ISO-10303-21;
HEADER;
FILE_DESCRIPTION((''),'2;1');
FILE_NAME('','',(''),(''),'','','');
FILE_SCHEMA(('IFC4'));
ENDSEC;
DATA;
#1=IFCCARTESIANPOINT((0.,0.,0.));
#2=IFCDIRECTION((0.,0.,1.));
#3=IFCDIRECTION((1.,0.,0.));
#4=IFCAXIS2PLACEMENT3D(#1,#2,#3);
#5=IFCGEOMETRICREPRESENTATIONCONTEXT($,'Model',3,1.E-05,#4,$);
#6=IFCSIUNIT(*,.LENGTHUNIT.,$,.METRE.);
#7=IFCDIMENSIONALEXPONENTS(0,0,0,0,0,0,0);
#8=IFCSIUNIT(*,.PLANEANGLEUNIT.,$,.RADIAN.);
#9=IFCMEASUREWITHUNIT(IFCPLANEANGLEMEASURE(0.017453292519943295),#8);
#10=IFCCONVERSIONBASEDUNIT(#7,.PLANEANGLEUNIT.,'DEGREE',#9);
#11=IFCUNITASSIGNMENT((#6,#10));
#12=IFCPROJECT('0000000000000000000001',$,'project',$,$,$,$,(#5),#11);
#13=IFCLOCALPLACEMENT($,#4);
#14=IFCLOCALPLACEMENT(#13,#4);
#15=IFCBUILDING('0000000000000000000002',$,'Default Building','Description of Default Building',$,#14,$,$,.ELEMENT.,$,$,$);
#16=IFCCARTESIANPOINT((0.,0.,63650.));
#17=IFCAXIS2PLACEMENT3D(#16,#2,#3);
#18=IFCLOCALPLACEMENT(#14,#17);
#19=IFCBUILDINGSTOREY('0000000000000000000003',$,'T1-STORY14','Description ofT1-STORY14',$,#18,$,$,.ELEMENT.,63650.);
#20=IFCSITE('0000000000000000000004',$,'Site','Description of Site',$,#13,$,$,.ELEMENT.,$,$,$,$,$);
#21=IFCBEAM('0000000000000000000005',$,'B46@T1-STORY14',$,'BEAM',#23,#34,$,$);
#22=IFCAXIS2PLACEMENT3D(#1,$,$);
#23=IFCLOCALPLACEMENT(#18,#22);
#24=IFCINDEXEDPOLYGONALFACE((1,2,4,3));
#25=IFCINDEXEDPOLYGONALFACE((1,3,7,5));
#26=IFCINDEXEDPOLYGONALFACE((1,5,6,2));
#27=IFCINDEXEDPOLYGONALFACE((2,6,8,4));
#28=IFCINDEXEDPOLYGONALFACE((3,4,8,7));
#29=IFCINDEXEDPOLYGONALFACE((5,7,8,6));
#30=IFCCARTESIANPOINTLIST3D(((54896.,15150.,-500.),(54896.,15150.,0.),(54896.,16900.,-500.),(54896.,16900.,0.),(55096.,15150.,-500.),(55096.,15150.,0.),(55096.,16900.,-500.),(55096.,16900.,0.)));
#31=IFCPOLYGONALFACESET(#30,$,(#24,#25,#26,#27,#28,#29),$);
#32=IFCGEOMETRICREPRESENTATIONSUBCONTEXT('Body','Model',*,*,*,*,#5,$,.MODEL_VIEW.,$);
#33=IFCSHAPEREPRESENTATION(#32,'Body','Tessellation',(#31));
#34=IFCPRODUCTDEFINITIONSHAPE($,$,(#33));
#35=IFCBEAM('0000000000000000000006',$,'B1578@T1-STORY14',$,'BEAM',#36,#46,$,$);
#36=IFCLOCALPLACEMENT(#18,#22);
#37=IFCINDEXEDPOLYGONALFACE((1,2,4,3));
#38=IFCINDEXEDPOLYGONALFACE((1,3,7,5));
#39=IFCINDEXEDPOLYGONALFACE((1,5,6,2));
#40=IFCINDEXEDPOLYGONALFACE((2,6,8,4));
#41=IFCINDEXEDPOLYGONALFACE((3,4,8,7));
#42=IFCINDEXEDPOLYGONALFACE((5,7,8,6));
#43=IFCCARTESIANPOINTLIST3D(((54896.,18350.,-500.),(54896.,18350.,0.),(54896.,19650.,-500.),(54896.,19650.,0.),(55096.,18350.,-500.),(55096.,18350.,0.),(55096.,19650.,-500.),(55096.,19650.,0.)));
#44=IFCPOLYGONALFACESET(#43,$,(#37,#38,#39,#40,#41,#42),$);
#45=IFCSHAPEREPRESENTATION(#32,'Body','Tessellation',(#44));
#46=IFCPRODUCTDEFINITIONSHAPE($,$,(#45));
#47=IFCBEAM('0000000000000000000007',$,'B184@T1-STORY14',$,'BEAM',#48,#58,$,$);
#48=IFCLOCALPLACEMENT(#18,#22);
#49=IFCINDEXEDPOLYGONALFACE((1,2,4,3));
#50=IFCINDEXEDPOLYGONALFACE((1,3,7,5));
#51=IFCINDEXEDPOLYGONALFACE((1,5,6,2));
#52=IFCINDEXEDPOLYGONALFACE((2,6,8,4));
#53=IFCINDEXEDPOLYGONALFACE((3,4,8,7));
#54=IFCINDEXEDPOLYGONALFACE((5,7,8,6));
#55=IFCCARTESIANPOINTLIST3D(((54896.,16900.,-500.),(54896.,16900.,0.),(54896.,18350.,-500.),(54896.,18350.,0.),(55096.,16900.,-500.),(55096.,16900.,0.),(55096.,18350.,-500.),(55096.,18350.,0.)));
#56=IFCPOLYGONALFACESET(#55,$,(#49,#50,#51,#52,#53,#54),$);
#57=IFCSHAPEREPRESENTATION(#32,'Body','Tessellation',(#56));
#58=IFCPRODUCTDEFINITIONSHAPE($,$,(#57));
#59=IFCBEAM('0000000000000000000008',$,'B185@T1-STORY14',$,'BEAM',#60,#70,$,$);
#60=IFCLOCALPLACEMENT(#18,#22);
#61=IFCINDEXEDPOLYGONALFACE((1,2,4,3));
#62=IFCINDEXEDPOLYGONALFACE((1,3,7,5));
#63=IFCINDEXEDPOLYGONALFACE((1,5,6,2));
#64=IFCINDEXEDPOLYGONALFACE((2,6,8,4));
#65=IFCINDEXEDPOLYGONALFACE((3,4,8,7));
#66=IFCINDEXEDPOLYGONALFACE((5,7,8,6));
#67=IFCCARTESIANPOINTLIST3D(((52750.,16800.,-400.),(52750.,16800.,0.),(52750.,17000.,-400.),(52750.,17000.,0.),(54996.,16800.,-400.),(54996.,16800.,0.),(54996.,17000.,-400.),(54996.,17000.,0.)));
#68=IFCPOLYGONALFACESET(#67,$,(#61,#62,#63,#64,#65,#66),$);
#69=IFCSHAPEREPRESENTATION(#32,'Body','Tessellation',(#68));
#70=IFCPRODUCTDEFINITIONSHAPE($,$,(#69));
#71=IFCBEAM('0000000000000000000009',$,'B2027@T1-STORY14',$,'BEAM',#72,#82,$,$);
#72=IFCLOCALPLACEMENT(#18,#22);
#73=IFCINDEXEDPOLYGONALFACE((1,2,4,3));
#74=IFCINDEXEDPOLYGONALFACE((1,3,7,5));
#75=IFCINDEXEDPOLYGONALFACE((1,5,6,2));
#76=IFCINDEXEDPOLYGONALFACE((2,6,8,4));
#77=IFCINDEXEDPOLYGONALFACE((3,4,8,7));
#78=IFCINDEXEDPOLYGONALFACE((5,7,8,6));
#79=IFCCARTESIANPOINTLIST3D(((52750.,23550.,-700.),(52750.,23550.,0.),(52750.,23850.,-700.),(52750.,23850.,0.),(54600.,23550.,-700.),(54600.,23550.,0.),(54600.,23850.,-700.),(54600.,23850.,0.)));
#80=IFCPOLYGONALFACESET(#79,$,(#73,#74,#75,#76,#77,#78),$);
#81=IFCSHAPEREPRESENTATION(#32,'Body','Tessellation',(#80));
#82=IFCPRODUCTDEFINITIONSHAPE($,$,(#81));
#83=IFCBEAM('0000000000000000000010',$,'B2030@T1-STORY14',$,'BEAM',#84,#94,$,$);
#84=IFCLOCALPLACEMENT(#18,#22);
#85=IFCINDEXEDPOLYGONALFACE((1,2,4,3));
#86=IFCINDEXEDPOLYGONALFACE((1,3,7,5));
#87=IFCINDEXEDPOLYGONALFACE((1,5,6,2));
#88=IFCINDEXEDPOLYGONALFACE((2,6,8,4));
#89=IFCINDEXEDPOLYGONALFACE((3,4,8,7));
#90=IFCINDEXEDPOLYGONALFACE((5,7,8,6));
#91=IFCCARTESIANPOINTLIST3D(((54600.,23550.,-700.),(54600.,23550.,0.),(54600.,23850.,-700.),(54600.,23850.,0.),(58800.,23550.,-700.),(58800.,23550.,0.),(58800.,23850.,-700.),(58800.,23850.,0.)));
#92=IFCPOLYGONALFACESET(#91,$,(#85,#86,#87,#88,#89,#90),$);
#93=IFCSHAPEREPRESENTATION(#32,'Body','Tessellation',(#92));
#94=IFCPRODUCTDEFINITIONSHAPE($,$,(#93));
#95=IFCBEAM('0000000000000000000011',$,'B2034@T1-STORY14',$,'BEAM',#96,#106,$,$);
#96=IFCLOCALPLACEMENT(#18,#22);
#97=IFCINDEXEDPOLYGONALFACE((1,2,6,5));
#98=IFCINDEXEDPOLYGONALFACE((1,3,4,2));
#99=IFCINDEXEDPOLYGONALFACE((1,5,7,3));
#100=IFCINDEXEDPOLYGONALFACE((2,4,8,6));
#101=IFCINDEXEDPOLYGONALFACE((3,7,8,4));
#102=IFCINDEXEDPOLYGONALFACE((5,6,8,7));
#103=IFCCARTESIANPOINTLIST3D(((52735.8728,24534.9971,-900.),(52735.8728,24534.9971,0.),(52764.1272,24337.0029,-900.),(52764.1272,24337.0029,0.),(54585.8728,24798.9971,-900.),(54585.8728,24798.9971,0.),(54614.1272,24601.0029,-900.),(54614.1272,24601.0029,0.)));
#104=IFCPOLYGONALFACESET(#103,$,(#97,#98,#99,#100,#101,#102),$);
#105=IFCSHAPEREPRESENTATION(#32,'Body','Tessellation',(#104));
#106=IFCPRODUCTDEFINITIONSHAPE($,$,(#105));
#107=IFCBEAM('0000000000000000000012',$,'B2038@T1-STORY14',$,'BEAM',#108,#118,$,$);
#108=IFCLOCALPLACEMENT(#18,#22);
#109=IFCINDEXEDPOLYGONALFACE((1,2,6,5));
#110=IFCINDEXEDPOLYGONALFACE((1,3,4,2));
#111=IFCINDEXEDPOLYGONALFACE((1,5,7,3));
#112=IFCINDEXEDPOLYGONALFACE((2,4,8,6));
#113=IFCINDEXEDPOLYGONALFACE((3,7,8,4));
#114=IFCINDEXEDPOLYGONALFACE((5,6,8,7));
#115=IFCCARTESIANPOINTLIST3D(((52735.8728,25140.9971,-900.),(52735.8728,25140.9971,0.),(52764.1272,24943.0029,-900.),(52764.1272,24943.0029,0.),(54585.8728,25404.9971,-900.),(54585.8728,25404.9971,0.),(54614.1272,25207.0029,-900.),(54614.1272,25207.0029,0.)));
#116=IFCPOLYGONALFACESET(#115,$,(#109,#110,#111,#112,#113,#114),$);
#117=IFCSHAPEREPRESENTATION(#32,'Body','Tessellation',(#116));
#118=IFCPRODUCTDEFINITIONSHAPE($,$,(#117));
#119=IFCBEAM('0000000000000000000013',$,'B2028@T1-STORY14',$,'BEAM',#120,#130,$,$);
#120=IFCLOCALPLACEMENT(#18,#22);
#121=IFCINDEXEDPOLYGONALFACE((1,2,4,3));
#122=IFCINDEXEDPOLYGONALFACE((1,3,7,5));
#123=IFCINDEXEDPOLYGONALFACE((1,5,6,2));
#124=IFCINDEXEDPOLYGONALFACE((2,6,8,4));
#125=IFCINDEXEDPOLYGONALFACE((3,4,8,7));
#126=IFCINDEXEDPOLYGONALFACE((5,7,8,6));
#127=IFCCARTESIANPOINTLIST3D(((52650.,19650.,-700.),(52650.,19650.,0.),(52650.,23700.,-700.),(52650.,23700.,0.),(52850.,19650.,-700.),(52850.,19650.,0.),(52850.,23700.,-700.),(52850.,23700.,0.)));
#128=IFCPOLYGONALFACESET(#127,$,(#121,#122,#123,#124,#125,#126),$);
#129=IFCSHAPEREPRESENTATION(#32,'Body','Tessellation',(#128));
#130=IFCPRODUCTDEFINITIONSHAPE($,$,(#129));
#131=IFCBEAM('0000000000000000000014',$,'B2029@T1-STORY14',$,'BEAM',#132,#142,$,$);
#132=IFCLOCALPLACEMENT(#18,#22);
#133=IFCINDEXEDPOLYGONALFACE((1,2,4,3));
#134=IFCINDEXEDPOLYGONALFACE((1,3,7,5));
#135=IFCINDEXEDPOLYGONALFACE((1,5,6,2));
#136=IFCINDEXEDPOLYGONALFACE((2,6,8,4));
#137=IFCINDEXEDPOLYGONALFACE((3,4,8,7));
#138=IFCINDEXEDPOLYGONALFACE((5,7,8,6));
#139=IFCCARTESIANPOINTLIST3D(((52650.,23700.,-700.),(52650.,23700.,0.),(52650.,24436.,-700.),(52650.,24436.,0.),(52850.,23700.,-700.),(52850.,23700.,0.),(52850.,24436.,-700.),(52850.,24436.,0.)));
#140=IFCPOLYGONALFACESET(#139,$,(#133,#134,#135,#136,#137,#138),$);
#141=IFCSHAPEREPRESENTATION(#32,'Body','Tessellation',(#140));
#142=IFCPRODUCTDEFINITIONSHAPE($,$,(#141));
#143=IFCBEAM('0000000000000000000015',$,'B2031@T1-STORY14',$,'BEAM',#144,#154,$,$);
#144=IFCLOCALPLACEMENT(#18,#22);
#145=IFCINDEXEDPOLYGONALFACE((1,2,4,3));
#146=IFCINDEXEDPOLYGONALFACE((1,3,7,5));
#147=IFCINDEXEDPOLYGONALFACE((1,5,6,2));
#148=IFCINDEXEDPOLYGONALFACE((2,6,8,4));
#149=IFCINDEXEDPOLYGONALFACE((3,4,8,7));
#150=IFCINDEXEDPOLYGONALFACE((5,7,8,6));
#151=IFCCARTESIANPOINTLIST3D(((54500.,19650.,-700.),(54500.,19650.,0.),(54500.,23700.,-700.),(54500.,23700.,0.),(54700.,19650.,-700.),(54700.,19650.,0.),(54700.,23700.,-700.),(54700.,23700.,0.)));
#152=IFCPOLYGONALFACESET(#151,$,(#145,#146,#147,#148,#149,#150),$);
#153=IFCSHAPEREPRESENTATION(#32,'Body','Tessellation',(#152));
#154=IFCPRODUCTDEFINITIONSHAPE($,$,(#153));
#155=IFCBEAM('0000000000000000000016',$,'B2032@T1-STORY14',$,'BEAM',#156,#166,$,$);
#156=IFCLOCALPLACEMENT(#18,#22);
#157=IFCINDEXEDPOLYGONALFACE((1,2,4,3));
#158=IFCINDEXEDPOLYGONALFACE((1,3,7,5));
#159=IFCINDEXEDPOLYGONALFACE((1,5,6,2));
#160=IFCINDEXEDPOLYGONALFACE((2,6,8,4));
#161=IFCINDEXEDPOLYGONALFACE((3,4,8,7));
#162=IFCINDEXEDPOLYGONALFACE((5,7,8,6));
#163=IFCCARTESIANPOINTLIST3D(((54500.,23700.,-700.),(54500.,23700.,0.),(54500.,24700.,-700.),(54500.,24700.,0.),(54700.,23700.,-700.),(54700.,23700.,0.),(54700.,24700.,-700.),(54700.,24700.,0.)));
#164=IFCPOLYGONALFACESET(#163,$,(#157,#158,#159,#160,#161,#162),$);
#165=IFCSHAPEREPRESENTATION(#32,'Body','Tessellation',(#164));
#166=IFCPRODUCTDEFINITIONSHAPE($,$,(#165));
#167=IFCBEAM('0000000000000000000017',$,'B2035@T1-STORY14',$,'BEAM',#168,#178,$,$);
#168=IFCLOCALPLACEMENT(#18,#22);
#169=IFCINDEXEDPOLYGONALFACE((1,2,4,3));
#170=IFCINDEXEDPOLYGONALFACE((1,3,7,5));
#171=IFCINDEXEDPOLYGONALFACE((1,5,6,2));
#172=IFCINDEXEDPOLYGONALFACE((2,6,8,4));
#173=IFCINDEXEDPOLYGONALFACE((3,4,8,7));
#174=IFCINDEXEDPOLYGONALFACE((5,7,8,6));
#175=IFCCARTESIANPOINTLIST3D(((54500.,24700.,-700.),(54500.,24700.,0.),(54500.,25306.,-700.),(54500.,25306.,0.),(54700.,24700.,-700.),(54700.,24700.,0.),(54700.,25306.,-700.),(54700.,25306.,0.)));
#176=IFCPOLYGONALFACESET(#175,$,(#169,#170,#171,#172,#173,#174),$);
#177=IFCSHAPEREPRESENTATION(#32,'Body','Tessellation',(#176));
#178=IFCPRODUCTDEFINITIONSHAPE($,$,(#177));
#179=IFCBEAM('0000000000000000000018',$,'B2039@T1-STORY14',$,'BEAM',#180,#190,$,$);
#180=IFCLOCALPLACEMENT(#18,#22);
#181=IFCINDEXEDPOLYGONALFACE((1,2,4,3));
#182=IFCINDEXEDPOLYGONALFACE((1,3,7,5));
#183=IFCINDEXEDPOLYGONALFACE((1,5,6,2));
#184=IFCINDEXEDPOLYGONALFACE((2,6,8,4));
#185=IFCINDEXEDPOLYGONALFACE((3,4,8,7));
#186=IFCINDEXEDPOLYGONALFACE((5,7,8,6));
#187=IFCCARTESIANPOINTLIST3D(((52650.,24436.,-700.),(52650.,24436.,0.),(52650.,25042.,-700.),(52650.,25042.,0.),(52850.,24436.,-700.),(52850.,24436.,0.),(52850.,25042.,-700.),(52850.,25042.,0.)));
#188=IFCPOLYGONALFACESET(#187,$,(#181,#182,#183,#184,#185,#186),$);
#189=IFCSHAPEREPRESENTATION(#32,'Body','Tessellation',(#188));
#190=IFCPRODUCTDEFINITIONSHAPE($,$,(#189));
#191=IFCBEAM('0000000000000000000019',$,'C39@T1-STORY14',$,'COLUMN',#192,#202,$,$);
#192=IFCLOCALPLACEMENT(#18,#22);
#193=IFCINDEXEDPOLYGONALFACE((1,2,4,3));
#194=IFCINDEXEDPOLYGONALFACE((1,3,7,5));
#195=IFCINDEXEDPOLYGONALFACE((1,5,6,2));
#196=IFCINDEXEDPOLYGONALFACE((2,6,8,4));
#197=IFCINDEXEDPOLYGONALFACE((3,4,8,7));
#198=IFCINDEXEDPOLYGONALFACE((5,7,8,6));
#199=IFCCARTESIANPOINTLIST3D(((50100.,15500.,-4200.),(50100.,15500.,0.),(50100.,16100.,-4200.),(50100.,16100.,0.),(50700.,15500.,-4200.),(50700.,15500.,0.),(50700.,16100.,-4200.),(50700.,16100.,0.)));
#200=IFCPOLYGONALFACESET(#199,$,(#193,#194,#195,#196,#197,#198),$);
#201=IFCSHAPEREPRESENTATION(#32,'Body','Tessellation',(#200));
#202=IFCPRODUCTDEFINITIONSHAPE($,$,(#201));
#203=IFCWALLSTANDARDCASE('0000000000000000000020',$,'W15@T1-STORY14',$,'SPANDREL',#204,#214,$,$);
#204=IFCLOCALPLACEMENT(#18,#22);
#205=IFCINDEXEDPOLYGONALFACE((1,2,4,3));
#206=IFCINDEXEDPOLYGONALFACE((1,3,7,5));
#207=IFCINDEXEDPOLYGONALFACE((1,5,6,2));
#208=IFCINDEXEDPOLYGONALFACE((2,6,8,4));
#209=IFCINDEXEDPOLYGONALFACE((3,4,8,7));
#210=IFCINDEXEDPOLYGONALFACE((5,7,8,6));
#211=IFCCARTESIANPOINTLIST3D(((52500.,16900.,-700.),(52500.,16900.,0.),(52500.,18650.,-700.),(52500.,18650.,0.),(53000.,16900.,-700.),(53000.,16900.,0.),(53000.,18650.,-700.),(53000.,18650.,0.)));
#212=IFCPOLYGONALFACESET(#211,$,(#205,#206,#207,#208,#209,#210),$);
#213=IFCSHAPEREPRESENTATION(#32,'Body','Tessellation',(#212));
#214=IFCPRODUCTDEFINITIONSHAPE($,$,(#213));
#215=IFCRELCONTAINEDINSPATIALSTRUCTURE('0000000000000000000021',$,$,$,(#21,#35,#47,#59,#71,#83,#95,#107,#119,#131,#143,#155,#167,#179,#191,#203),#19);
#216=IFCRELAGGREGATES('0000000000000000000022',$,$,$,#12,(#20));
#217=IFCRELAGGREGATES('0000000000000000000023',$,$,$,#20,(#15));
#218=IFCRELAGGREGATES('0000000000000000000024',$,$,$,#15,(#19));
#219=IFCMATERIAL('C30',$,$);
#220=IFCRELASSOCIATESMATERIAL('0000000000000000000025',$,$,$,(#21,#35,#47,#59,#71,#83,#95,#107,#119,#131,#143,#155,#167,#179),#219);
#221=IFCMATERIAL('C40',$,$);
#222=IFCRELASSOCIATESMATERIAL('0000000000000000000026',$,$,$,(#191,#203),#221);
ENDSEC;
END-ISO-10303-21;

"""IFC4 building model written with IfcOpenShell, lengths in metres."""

from ifc_helpers import new_model, entity, si_unit, converted_unit, frame, origin_with_axes, place, context, subcontext, project, spatial, indexed_curve, rectangle, outline, extrude, material, element, save


model = new_model("IFC4")

# Units and contexts
model_context = context("Model", 3, precision=1e-05, world=origin_with_axes())
body_context = subcontext(model_context, "Body", "Model", "MODEL_VIEW")
ifc_project = project(units=[si_unit("LENGTHUNIT", "METRE"), converted_unit("PLANEANGLEUNIT", "DEGREE", entity("IfcPlaneAngleMeasure", 0.017453292519943295), si_unit("PLANEANGLEUNIT", "RADIAN"), dimensions=[0, 0, 0, 0, 0, 0, 0])], contexts=[model_context])

# Site, building, storey
site_placement = place(None, origin_with_axes())
site = spatial("IfcSite", under=ifc_project, at=site_placement, Name="Site", Description="Description of Site", CompositionType="ELEMENT")
building_placement = place(site_placement, origin_with_axes())
building = spatial("IfcBuilding", under=site, at=building_placement, Name="Default Building", Description="Description of Default Building", CompositionType="ELEMENT")
storey_placement = place(building_placement, frame((0.0, 0.0, 63650.0), z_axis=(0.0, 0.0, 1.0), x_axis=(1.0, 0.0, 0.0)))
storey = spatial("IfcBuildingStorey", under=building, at=storey_placement, Name="T1-STORY14", Description="Description ofT1-STORY14", CompositionType="ELEMENT", Elevation=63650.0)

# Beams
ifc_material_1 = material(Name="C30")
beam_1_placement = place(storey_placement, frame((54996.0, 15150.0, -250.0), z_axis=(0.0, 1.0, 0.0), x_axis=(-1.0, 0.0, 0.0)))
element("IfcBeam", 1, at=beam_1_placement, inside=storey, material=ifc_material_1, Name="B46@T1-STORY14", ObjectType="BEAM", context=body_context, shape_type="SweptSolid", body=[
    extrude(rectangle(XDim=200.0, YDim=500.0), origin_with_axes(), (0.0, 0.0, 1.0), 1750.0),
])
beam_2_placement = place(storey_placement, frame((54996.0, 18350.0, -250.0), z_axis=(0.0, 1.0, 0.0), x_axis=(-1.0, 0.0, 0.0)))
element("IfcBeam", 2, at=beam_2_placement, inside=storey, material=ifc_material_1, Name="B1578@T1-STORY14", ObjectType="BEAM", context=body_context, shape_type="SweptSolid", body=[
    extrude(rectangle(XDim=200.0, YDim=500.0), origin_with_axes(), (0.0, 0.0, 1.0), 1300.0),
])
beam_3_placement = place(storey_placement, frame((54996.0, 16900.0, -250.0), z_axis=(0.0, 1.0, 0.0), x_axis=(-1.0, 0.0, 0.0)))
element("IfcBeam", 3, at=beam_3_placement, inside=storey, material=ifc_material_1, Name="B184@T1-STORY14", ObjectType="BEAM", context=body_context, shape_type="SweptSolid", body=[
    extrude(rectangle(XDim=200.0, YDim=500.0), origin_with_axes(), (0.0, 0.0, 1.0), 1450.0),
])
beam_4_placement = place(storey_placement, frame((52750.0, 16900.0, -200.0), z_axis=(1.0, 0.0, 0.0), x_axis=(0.0, 1.0, 0.0)))
element("IfcBeam", 4, at=beam_4_placement, inside=storey, material=ifc_material_1, Name="B185@T1-STORY14", ObjectType="BEAM", context=body_context, shape_type="SweptSolid", body=[
    extrude(rectangle(XDim=200.0, YDim=400.0), origin_with_axes(), (0.0, 0.0, 1.0), 2246.0),
])
beam_5_placement = place(storey_placement, frame((52750.0, 23700.0, -350.0), z_axis=(1.0, 0.0, 0.0), x_axis=(0.0, 1.0, 0.0)))
element("IfcBeam", 5, at=beam_5_placement, inside=storey, material=ifc_material_1, Name="B2027@T1-STORY14", ObjectType="BEAM", context=body_context, shape_type="SweptSolid", body=[
    extrude(rectangle(XDim=300.0, YDim=700.0), origin_with_axes(), (0.0, 0.0, 1.0), 1850.0),
])
beam_6_placement = place(storey_placement, frame((54600.0, 23700.0, -350.0), z_axis=(1.0, 0.0, 0.0), x_axis=(0.0, 1.0, 0.0)))
element("IfcBeam", 6, at=beam_6_placement, inside=storey, material=ifc_material_1, Name="B2030@T1-STORY14", ObjectType="BEAM", context=body_context, shape_type="SweptSolid", body=[
    extrude(rectangle(XDim=300.0, YDim=700.0), origin_with_axes(), (0.0, 0.0, 1.0), 4200.0),
])
for number, where, z_axis, x_axis, name in (
    (7, (52750.0, 24436.0, -450.0), (0.989971, 0.141272, 0.0), (-0.141272, 0.989971, 0.0), "B2034@T1-STORY14"),
    (8, (52750.0, 25042.0, -450.0), (0.989971, 0.141272, 0.0), (-0.141272, 0.989971, 0.0), "B2038@T1-STORY14"),
):
    element("IfcBeam", number, at=place(storey_placement, frame(where, z_axis=z_axis, x_axis=x_axis)), inside=storey, material=ifc_material_1, Name=name, ObjectType="BEAM", context=body_context, shape_type="SweptSolid", body=[
        extrude(rectangle(XDim=200.0, YDim=900.0), origin_with_axes(), (0.0, 0.0, 1.0), 1868.7418),
    ])
beam_7_placement = place(storey_placement, frame((52750.0, 19650.0, -350.0), z_axis=(0.0, 1.0, 0.0), x_axis=(-1.0, 0.0, 0.0)))
element("IfcBeam", 9, at=beam_7_placement, inside=storey, material=ifc_material_1, Name="B2028@T1-STORY14", ObjectType="BEAM", context=body_context, shape_type="SweptSolid", body=[
    extrude(rectangle(XDim=200.0, YDim=700.0), origin_with_axes(), (0.0, 0.0, 1.0), 4050.0),
])
beam_8_placement = place(storey_placement, frame((52750.0, 23700.0, -350.0), z_axis=(0.0, 1.0, 0.0), x_axis=(-1.0, 0.0, 0.0)))
element("IfcBeam", 10, at=beam_8_placement, inside=storey, material=ifc_material_1, Name="B2029@T1-STORY14", ObjectType="BEAM", context=body_context, shape_type="SweptSolid", body=[
    extrude(rectangle(XDim=200.0, YDim=700.0), origin_with_axes(), (0.0, 0.0, 1.0), 736.0),
])
beam_9_placement = place(storey_placement, frame((54600.0, 19650.0, -350.0), z_axis=(0.0, 1.0, 0.0), x_axis=(-1.0, 0.0, 0.0)))
element("IfcBeam", 11, at=beam_9_placement, inside=storey, material=ifc_material_1, Name="B2031@T1-STORY14", ObjectType="BEAM", context=body_context, shape_type="SweptSolid", body=[
    extrude(rectangle(XDim=200.0, YDim=700.0), origin_with_axes(), (0.0, 0.0, 1.0), 4050.0),
])
beam_10_placement = place(storey_placement, frame((54600.0, 23700.0, -350.0), z_axis=(0.0, 1.0, 0.0), x_axis=(-1.0, 0.0, 0.0)))
element("IfcBeam", 12, at=beam_10_placement, inside=storey, material=ifc_material_1, Name="B2032@T1-STORY14", ObjectType="BEAM", context=body_context, shape_type="SweptSolid", body=[
    extrude(rectangle(XDim=200.0, YDim=700.0), origin_with_axes(), (0.0, 0.0, 1.0), 1000.0),
])
for number, where, z_axis, x_axis, name in (
    (13, (54600.0, 24700.0, -350.0), (0.0, 1.0, 0.0), (-1.0, 0.0, 0.0), "B2035@T1-STORY14"),
    (14, (52750.0, 24436.0, -350.0), (0.0, 1.0, 0.0), (-1.0, 0.0, 0.0), "B2039@T1-STORY14"),
):
    element("IfcBeam", number, at=place(storey_placement, frame(where, z_axis=z_axis, x_axis=x_axis)), inside=storey, material=ifc_material_1, Name=name, ObjectType="BEAM", context=body_context, shape_type="SweptSolid", body=[
        extrude(rectangle(XDim=200.0, YDim=700.0), origin_with_axes(), (0.0, 0.0, 1.0), 606.0),
    ])
ifc_material_2 = material(Name="C40")
beam_11_placement = place(storey_placement, frame((50400.0, 15800.0, -4200.0), z_axis=(0.0, 0.0, 1.0), x_axis=(-1.0, 0.0, 0.0)))
element("IfcBeam", 15, at=beam_11_placement, inside=storey, material=ifc_material_2, Name="C39@T1-STORY14", ObjectType="COLUMN", context=body_context, shape_type="SweptSolid", body=[
    extrude(rectangle(XDim=600.0, YDim=600.0), origin_with_axes(), (0.0, 0.0, 1.0), 4200.0),
])

# Wall
wall_1_placement = place(storey_placement, frame((52750.0, 16900.0, -700.0), z_axis=(0.0, 0.0, 1.0), x_axis=(0.0, 1.0, 0.0)))
element("IfcWallStandardCase", 16, at=wall_1_placement, inside=storey, material=ifc_material_2, Name="W15@T1-STORY14", ObjectType="SPANDREL", context=body_context, shape_type="SweptSolid", body=[
    extrude(outline(indexed_curve([(0.0, -250.0), (0.0, 250.0), (1750.0, 250.0), (1750.0, -250.0), (0.0, -250.0)], self_intersect=False)), origin_with_axes(), (0.0, 0.0, 1.0), 700.0),
])

save(model, "model.ifc")
